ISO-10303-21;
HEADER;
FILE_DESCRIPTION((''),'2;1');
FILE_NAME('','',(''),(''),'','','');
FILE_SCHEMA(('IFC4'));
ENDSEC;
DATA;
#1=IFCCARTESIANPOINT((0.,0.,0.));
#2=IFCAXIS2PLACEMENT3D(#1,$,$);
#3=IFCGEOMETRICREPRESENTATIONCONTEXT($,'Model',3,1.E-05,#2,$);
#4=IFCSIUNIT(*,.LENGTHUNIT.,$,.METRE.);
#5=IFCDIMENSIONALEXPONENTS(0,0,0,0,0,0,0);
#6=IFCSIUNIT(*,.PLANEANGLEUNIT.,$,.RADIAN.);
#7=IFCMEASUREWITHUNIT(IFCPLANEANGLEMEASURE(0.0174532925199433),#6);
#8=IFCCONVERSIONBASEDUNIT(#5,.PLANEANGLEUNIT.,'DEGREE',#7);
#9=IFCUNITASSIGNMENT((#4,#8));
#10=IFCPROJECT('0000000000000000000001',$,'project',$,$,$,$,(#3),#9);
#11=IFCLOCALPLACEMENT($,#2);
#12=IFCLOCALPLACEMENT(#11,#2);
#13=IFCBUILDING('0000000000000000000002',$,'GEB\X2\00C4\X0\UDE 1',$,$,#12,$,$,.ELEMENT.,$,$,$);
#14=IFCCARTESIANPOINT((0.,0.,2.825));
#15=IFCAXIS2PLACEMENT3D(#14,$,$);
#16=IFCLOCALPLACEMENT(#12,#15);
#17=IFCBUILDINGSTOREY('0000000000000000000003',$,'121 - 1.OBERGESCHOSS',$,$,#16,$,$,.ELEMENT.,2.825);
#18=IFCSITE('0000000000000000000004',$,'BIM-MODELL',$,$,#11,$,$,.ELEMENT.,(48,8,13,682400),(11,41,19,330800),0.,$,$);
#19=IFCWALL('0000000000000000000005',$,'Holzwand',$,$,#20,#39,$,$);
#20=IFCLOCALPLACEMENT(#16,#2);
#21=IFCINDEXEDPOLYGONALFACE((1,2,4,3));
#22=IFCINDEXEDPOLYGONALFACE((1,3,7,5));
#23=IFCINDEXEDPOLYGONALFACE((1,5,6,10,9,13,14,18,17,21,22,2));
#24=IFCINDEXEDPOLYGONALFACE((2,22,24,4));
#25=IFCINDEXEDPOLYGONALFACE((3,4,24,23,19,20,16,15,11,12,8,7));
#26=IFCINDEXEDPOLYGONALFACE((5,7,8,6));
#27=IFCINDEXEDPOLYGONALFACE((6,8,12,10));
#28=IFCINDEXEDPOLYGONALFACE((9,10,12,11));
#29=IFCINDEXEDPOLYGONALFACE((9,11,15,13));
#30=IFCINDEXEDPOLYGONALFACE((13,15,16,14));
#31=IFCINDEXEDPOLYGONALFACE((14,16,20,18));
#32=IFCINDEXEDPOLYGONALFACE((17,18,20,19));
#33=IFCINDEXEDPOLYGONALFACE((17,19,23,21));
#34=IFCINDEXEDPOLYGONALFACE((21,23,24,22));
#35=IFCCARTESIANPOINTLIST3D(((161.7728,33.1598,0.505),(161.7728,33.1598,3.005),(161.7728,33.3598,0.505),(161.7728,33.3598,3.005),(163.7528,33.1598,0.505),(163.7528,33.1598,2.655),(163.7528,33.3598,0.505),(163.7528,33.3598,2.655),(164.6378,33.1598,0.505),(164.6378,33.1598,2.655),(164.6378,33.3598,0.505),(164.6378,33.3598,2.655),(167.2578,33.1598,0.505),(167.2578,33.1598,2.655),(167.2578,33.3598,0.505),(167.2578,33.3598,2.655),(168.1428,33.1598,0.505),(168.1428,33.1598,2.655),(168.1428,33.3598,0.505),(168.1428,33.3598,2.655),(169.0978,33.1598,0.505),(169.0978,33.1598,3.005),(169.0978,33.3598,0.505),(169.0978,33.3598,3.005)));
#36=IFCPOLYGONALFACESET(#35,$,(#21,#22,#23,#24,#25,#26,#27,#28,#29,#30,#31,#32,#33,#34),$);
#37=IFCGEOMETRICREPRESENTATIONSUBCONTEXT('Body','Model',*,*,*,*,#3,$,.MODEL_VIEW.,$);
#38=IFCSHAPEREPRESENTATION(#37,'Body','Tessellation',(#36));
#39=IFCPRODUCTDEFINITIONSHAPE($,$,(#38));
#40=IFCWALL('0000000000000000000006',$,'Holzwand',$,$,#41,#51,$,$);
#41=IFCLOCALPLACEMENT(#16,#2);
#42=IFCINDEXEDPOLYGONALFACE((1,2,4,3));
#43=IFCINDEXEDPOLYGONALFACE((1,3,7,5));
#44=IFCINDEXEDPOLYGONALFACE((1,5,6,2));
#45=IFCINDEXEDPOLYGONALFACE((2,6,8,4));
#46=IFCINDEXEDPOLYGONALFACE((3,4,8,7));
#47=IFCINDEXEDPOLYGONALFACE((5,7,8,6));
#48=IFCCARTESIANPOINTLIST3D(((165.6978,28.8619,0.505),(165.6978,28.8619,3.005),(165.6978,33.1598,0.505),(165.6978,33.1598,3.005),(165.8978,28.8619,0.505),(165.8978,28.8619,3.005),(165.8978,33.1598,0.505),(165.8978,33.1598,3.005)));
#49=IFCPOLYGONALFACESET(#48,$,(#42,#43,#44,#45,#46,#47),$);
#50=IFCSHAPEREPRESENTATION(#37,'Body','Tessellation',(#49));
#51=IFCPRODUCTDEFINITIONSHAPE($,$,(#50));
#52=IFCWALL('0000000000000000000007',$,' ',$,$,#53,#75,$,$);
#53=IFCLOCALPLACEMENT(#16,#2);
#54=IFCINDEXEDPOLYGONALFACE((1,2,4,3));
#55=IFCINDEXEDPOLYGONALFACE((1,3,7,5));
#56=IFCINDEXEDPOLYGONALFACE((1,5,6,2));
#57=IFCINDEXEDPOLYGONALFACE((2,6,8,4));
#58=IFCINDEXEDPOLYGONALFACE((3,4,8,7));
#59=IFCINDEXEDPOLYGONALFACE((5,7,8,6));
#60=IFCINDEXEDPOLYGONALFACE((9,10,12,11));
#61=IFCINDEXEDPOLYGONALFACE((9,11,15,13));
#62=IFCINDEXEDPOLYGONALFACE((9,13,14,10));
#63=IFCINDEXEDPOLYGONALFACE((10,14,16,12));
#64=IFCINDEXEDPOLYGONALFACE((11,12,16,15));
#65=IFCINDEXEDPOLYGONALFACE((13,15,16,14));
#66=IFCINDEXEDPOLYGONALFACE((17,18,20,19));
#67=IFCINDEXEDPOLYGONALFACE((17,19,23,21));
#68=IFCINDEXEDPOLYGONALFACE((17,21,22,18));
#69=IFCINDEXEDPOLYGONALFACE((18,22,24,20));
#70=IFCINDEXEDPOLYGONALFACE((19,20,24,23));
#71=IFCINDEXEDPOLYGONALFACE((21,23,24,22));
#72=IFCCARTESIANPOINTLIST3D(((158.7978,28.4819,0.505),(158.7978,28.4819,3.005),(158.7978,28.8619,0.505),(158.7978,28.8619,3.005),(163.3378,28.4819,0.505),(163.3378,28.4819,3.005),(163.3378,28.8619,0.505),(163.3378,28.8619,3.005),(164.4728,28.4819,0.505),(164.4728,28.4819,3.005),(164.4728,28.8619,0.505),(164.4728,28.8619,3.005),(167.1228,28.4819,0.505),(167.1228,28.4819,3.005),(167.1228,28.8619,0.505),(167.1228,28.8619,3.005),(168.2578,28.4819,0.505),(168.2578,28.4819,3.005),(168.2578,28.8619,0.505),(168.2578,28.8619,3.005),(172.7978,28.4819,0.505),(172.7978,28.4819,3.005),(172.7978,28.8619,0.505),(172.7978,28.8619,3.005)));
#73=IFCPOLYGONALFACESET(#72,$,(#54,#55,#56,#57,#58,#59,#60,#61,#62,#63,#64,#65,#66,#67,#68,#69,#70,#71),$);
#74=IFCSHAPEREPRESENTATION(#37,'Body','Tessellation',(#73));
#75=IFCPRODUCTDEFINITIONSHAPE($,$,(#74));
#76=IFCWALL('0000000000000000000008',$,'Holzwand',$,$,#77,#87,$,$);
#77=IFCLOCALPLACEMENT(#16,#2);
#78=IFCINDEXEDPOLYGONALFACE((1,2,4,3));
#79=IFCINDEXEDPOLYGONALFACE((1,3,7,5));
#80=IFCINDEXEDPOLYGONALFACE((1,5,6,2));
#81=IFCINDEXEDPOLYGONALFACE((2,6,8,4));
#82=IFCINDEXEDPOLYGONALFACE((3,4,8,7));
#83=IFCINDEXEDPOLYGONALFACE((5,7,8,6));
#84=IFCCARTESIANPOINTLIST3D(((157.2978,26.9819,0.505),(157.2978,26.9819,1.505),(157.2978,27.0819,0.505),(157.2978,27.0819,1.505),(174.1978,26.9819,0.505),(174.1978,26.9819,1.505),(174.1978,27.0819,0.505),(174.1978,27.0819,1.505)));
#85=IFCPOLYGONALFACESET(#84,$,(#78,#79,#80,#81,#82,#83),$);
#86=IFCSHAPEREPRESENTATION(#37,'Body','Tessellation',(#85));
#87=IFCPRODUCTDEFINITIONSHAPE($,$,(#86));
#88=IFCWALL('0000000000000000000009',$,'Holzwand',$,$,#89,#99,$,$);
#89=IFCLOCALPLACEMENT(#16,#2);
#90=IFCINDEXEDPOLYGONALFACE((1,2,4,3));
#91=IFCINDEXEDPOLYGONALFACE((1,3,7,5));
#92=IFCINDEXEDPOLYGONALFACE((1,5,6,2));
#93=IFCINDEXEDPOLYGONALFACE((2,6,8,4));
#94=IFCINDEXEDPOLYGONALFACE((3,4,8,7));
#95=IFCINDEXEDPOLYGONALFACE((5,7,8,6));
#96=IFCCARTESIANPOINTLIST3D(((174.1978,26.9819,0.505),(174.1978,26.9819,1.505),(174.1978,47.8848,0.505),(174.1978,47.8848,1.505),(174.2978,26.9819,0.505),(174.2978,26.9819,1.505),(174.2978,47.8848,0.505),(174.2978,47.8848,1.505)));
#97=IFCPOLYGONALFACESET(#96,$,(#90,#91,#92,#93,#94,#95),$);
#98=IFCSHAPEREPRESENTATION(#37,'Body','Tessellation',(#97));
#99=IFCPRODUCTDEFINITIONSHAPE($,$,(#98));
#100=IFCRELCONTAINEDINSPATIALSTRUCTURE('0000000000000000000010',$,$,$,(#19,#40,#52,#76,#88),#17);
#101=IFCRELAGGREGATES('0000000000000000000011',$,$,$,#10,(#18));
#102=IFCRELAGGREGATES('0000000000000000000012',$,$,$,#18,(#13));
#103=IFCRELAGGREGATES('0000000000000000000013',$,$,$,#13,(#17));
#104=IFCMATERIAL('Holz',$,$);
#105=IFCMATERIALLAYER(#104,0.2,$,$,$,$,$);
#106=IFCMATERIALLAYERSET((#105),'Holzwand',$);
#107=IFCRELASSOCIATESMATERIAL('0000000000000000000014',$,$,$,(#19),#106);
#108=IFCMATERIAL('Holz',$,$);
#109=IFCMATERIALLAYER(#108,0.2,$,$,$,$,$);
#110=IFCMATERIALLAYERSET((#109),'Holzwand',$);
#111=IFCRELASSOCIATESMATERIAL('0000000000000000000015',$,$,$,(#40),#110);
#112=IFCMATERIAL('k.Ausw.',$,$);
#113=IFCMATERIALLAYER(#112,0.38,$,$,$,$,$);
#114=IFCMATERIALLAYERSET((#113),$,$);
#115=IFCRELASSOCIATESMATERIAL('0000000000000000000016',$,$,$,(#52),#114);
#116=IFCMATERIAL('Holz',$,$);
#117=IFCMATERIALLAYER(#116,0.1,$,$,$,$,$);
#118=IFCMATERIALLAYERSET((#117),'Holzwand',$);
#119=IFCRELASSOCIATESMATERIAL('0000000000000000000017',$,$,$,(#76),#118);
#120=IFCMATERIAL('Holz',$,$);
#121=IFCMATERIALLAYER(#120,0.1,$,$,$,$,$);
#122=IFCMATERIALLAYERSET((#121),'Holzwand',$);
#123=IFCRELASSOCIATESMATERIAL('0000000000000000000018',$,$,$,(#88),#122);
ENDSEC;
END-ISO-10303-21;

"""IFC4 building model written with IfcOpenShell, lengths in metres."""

from ifc_helpers import new_model, entity, si_unit, converted_unit, frame, frame_2d, origin, origin_with_axes, place, context, subcontext, project, spatial, polyline, rectangle, outline, extrude, material, layer, layer_set, layer_usage, element, save


model = new_model("IFC4")

# Units and contexts
model_context = context("Model", 3, precision=1e-05, world=origin())
body_context = subcontext(model_context, "Body", "Model", "MODEL_VIEW")
ifc_project = project(units=[si_unit("LENGTHUNIT", "METRE"), converted_unit("PLANEANGLEUNIT", "DEGREE", entity("IfcPlaneAngleMeasure", 0.0174532925199433), si_unit("PLANEANGLEUNIT", "RADIAN"), dimensions=[0, 0, 0, 0, 0, 0, 0])], contexts=[model_context])

# Site, building, storey
site_placement = place(None, origin())
site = spatial("IfcSite", under=ifc_project, at=site_placement, Name="BIM-MODELL", CompositionType="ELEMENT", RefLatitude=(48, 8, 13, 682400), RefLongitude=(11, 41, 19, 330800), RefElevation=0.0)
building_placement = place(site_placement, origin())
building = spatial("IfcBuilding", under=site, at=building_placement, Name="GEBÄUDE 1", CompositionType="ELEMENT")
storey_placement = place(building_placement, frame((0.0, 0.0, 2.825)))
storey = spatial("IfcBuildingStorey", under=building, at=storey_placement, Name="121 - 1.OBERGESCHOSS", CompositionType="ELEMENT", Elevation=2.825)

# Wall, openings
ifc_material_1 = material(Name="Holz")
ifc_layer_1 = layer(ifc_material_1, 0.2)
ifc_layer_set_1 = layer_set([ifc_layer_1], Name="Holzwand")
ifc_layer_usage_1 = layer_usage(ifc_layer_set_1, "AXIS2", "POSITIVE", 0.0)
wall_1_placement = place(storey_placement, frame((169.0978, 33.3598, 0.505), z_axis=(0.0, 0.0, 1.0), x_axis=(-1.0, 0.0, 0.0)))
wall_1 = element("IfcWall", 1, at=wall_1_placement, inside=storey, material=ifc_layer_usage_1, Name="Holzwand", context=body_context, shape_type="SweptSolid", body=[
    extrude(rectangle(XDim=7.325, YDim=0.2, at=frame_2d((3.6625, 0.1), x_axis=(1.0, 0.0))), origin_with_axes(), (0.0, 0.0, 1.0), 2.5),
])
opening_1_placement = place(wall_1_placement, frame((0.955, 0.0, -0.15), z_axis=(0.0, 1.0, 0.0), x_axis=(0.0, 0.0, 1.0)))
element("IfcOpeningElement", 2, at=opening_1_placement, cuts=wall_1, ObjectType="Opening", context=body_context, shape_type="SweptSolid", body=[
    extrude(outline(polyline([(0.0, 0.885), (2.3, 0.885), (2.3, 0.0), (0.0, 0.0), (0.0, 0.885)])), origin_with_axes(), (0.0, 0.0, 1.0), 0.2),
])
opening_2_placement = place(wall_1_placement, frame((4.46, 0.0, -0.15), z_axis=(0.0, 1.0, 0.0), x_axis=(0.0, 0.0, 1.0)))
element("IfcOpeningElement", 3, at=opening_2_placement, cuts=wall_1, ObjectType="Opening", context=body_context, shape_type="SweptSolid", body=[
    extrude(outline(polyline([(0.0, 0.885), (2.3, 0.885), (2.3, 0.0), (0.0, 0.0), (0.0, 0.885)])), origin_with_axes(), (0.0, 0.0, 1.0), 0.2),
])

# Wall
ifc_material_2 = material(Name="Holz")
ifc_layer_2 = layer(ifc_material_2, 0.2)
ifc_layer_set_2 = layer_set([ifc_layer_2], Name="Holzwand")
ifc_layer_usage_2 = layer_usage(ifc_layer_set_2, "AXIS2", "POSITIVE", 0.0)
wall_2_placement = place(storey_placement, frame((165.6978, 33.1598, 0.505), z_axis=(0.0, 0.0, 1.0), x_axis=(0.0, -1.0, 0.0)))
element("IfcWall", 4, at=wall_2_placement, inside=storey, material=ifc_layer_usage_2, Name="Holzwand", context=body_context, shape_type="SweptSolid", body=[
    extrude(rectangle(XDim=4.2979, YDim=0.2, at=frame_2d((2.1489, 0.1), x_axis=(1.0, 0.0))), origin_with_axes(), (0.0, 0.0, 1.0), 2.5),
])

# Wall, openings
ifc_material_3 = material(Name="k.Ausw.")
ifc_layer_3 = layer(ifc_material_3, 0.38)
ifc_layer_set_3 = layer_set([ifc_layer_3])
ifc_layer_usage_3 = layer_usage(ifc_layer_set_3, "AXIS2", "POSITIVE", 0.0)
wall_3_placement = place(storey_placement, frame((158.7978, 28.4819, 0.505), z_axis=(0.0, 0.0, 1.0), x_axis=(1.0, 0.0, 0.0)))
wall_3 = element("IfcWall", 5, at=wall_3_placement, inside=storey, material=ifc_layer_usage_3, Name=" ", context=body_context, shape_type="SweptSolid", body=[
    extrude(rectangle(XDim=14.0, YDim=0.38, at=frame_2d((7.0, 0.19), x_axis=(1.0, 0.0))), origin_with_axes(), (0.0, 0.0, 1.0), 2.5),
])
opening_3_placement = place(wall_3_placement, frame((9.46, 0.38, 0.0), z_axis=(0.0, -1.0, 0.0), x_axis=(0.0, 0.0, 1.0)))
element("IfcOpeningElement", 6, at=opening_3_placement, cuts=wall_3, ObjectType="Opening", context=body_context, shape_type="SweptSolid", body=[
    extrude(outline(polyline([(0.0, 1.135), (2.5, 1.135), (2.5, 0.0), (0.0, 0.0), (0.0, 1.135)])), origin_with_axes(), (0.0, 0.0, 1.0), 0.38),
])
opening_4_placement = place(wall_3_placement, frame((5.675, 0.38, 0.0), z_axis=(0.0, -1.0, 0.0), x_axis=(0.0, 0.0, 1.0)))
element("IfcOpeningElement", 7, at=opening_4_placement, cuts=wall_3, ObjectType="Opening", context=body_context, shape_type="SweptSolid", body=[
    extrude(outline(polyline([(0.0, 1.135), (2.5, 1.135), (2.5, 0.0), (0.0, 0.0), (0.0, 1.135)])), origin_with_axes(), (0.0, 0.0, 1.0), 0.38),
])

# Walls
ifc_material_4 = material(Name="Holz")
ifc_layer_4 = layer(ifc_material_4, 0.1)
ifc_layer_set_4 = layer_set([ifc_layer_4], Name="Holzwand")
ifc_layer_usage_4 = layer_usage(ifc_layer_set_4, "AXIS2", "POSITIVE", 0.0)
wall_4_placement = place(storey_placement, frame((157.2978, 26.9819, 0.505)))
element("IfcWall", 8, at=wall_4_placement, inside=storey, material=ifc_layer_usage_4, Name="Holzwand", context=body_context, shape_type="SweptSolid", body=[
    extrude(rectangle(XDim=16.9, YDim=0.1, at=frame_2d((8.45, 0.05), x_axis=(1.0, 0.0))), origin_with_axes(), (0.0, 0.0, 1.0), 1.0),
])
ifc_material_5 = material(Name="Holz")
ifc_layer_5 = layer(ifc_material_5, 0.1)
ifc_layer_set_5 = layer_set([ifc_layer_5], Name="Holzwand")
ifc_layer_usage_5 = layer_usage(ifc_layer_set_5, "AXIS2", "POSITIVE", 0.0)
wall_5_placement = place(storey_placement, frame((174.2978, 26.9819, 0.505), z_axis=(0.0, 0.0, 1.0), x_axis=(0.0, 1.0, 0.0)))
element("IfcWall", 9, at=wall_5_placement, inside=storey, material=ifc_layer_usage_5, Name="Holzwand", context=body_context, shape_type="SweptSolid", body=[
    extrude(rectangle(XDim=20.9029, YDim=0.1, at=frame_2d((10.4514, 0.05), x_axis=(1.0, 0.0))), origin_with_axes(), (0.0, 0.0, 1.0), 1.0),
])

save(model, "model.ifc")
